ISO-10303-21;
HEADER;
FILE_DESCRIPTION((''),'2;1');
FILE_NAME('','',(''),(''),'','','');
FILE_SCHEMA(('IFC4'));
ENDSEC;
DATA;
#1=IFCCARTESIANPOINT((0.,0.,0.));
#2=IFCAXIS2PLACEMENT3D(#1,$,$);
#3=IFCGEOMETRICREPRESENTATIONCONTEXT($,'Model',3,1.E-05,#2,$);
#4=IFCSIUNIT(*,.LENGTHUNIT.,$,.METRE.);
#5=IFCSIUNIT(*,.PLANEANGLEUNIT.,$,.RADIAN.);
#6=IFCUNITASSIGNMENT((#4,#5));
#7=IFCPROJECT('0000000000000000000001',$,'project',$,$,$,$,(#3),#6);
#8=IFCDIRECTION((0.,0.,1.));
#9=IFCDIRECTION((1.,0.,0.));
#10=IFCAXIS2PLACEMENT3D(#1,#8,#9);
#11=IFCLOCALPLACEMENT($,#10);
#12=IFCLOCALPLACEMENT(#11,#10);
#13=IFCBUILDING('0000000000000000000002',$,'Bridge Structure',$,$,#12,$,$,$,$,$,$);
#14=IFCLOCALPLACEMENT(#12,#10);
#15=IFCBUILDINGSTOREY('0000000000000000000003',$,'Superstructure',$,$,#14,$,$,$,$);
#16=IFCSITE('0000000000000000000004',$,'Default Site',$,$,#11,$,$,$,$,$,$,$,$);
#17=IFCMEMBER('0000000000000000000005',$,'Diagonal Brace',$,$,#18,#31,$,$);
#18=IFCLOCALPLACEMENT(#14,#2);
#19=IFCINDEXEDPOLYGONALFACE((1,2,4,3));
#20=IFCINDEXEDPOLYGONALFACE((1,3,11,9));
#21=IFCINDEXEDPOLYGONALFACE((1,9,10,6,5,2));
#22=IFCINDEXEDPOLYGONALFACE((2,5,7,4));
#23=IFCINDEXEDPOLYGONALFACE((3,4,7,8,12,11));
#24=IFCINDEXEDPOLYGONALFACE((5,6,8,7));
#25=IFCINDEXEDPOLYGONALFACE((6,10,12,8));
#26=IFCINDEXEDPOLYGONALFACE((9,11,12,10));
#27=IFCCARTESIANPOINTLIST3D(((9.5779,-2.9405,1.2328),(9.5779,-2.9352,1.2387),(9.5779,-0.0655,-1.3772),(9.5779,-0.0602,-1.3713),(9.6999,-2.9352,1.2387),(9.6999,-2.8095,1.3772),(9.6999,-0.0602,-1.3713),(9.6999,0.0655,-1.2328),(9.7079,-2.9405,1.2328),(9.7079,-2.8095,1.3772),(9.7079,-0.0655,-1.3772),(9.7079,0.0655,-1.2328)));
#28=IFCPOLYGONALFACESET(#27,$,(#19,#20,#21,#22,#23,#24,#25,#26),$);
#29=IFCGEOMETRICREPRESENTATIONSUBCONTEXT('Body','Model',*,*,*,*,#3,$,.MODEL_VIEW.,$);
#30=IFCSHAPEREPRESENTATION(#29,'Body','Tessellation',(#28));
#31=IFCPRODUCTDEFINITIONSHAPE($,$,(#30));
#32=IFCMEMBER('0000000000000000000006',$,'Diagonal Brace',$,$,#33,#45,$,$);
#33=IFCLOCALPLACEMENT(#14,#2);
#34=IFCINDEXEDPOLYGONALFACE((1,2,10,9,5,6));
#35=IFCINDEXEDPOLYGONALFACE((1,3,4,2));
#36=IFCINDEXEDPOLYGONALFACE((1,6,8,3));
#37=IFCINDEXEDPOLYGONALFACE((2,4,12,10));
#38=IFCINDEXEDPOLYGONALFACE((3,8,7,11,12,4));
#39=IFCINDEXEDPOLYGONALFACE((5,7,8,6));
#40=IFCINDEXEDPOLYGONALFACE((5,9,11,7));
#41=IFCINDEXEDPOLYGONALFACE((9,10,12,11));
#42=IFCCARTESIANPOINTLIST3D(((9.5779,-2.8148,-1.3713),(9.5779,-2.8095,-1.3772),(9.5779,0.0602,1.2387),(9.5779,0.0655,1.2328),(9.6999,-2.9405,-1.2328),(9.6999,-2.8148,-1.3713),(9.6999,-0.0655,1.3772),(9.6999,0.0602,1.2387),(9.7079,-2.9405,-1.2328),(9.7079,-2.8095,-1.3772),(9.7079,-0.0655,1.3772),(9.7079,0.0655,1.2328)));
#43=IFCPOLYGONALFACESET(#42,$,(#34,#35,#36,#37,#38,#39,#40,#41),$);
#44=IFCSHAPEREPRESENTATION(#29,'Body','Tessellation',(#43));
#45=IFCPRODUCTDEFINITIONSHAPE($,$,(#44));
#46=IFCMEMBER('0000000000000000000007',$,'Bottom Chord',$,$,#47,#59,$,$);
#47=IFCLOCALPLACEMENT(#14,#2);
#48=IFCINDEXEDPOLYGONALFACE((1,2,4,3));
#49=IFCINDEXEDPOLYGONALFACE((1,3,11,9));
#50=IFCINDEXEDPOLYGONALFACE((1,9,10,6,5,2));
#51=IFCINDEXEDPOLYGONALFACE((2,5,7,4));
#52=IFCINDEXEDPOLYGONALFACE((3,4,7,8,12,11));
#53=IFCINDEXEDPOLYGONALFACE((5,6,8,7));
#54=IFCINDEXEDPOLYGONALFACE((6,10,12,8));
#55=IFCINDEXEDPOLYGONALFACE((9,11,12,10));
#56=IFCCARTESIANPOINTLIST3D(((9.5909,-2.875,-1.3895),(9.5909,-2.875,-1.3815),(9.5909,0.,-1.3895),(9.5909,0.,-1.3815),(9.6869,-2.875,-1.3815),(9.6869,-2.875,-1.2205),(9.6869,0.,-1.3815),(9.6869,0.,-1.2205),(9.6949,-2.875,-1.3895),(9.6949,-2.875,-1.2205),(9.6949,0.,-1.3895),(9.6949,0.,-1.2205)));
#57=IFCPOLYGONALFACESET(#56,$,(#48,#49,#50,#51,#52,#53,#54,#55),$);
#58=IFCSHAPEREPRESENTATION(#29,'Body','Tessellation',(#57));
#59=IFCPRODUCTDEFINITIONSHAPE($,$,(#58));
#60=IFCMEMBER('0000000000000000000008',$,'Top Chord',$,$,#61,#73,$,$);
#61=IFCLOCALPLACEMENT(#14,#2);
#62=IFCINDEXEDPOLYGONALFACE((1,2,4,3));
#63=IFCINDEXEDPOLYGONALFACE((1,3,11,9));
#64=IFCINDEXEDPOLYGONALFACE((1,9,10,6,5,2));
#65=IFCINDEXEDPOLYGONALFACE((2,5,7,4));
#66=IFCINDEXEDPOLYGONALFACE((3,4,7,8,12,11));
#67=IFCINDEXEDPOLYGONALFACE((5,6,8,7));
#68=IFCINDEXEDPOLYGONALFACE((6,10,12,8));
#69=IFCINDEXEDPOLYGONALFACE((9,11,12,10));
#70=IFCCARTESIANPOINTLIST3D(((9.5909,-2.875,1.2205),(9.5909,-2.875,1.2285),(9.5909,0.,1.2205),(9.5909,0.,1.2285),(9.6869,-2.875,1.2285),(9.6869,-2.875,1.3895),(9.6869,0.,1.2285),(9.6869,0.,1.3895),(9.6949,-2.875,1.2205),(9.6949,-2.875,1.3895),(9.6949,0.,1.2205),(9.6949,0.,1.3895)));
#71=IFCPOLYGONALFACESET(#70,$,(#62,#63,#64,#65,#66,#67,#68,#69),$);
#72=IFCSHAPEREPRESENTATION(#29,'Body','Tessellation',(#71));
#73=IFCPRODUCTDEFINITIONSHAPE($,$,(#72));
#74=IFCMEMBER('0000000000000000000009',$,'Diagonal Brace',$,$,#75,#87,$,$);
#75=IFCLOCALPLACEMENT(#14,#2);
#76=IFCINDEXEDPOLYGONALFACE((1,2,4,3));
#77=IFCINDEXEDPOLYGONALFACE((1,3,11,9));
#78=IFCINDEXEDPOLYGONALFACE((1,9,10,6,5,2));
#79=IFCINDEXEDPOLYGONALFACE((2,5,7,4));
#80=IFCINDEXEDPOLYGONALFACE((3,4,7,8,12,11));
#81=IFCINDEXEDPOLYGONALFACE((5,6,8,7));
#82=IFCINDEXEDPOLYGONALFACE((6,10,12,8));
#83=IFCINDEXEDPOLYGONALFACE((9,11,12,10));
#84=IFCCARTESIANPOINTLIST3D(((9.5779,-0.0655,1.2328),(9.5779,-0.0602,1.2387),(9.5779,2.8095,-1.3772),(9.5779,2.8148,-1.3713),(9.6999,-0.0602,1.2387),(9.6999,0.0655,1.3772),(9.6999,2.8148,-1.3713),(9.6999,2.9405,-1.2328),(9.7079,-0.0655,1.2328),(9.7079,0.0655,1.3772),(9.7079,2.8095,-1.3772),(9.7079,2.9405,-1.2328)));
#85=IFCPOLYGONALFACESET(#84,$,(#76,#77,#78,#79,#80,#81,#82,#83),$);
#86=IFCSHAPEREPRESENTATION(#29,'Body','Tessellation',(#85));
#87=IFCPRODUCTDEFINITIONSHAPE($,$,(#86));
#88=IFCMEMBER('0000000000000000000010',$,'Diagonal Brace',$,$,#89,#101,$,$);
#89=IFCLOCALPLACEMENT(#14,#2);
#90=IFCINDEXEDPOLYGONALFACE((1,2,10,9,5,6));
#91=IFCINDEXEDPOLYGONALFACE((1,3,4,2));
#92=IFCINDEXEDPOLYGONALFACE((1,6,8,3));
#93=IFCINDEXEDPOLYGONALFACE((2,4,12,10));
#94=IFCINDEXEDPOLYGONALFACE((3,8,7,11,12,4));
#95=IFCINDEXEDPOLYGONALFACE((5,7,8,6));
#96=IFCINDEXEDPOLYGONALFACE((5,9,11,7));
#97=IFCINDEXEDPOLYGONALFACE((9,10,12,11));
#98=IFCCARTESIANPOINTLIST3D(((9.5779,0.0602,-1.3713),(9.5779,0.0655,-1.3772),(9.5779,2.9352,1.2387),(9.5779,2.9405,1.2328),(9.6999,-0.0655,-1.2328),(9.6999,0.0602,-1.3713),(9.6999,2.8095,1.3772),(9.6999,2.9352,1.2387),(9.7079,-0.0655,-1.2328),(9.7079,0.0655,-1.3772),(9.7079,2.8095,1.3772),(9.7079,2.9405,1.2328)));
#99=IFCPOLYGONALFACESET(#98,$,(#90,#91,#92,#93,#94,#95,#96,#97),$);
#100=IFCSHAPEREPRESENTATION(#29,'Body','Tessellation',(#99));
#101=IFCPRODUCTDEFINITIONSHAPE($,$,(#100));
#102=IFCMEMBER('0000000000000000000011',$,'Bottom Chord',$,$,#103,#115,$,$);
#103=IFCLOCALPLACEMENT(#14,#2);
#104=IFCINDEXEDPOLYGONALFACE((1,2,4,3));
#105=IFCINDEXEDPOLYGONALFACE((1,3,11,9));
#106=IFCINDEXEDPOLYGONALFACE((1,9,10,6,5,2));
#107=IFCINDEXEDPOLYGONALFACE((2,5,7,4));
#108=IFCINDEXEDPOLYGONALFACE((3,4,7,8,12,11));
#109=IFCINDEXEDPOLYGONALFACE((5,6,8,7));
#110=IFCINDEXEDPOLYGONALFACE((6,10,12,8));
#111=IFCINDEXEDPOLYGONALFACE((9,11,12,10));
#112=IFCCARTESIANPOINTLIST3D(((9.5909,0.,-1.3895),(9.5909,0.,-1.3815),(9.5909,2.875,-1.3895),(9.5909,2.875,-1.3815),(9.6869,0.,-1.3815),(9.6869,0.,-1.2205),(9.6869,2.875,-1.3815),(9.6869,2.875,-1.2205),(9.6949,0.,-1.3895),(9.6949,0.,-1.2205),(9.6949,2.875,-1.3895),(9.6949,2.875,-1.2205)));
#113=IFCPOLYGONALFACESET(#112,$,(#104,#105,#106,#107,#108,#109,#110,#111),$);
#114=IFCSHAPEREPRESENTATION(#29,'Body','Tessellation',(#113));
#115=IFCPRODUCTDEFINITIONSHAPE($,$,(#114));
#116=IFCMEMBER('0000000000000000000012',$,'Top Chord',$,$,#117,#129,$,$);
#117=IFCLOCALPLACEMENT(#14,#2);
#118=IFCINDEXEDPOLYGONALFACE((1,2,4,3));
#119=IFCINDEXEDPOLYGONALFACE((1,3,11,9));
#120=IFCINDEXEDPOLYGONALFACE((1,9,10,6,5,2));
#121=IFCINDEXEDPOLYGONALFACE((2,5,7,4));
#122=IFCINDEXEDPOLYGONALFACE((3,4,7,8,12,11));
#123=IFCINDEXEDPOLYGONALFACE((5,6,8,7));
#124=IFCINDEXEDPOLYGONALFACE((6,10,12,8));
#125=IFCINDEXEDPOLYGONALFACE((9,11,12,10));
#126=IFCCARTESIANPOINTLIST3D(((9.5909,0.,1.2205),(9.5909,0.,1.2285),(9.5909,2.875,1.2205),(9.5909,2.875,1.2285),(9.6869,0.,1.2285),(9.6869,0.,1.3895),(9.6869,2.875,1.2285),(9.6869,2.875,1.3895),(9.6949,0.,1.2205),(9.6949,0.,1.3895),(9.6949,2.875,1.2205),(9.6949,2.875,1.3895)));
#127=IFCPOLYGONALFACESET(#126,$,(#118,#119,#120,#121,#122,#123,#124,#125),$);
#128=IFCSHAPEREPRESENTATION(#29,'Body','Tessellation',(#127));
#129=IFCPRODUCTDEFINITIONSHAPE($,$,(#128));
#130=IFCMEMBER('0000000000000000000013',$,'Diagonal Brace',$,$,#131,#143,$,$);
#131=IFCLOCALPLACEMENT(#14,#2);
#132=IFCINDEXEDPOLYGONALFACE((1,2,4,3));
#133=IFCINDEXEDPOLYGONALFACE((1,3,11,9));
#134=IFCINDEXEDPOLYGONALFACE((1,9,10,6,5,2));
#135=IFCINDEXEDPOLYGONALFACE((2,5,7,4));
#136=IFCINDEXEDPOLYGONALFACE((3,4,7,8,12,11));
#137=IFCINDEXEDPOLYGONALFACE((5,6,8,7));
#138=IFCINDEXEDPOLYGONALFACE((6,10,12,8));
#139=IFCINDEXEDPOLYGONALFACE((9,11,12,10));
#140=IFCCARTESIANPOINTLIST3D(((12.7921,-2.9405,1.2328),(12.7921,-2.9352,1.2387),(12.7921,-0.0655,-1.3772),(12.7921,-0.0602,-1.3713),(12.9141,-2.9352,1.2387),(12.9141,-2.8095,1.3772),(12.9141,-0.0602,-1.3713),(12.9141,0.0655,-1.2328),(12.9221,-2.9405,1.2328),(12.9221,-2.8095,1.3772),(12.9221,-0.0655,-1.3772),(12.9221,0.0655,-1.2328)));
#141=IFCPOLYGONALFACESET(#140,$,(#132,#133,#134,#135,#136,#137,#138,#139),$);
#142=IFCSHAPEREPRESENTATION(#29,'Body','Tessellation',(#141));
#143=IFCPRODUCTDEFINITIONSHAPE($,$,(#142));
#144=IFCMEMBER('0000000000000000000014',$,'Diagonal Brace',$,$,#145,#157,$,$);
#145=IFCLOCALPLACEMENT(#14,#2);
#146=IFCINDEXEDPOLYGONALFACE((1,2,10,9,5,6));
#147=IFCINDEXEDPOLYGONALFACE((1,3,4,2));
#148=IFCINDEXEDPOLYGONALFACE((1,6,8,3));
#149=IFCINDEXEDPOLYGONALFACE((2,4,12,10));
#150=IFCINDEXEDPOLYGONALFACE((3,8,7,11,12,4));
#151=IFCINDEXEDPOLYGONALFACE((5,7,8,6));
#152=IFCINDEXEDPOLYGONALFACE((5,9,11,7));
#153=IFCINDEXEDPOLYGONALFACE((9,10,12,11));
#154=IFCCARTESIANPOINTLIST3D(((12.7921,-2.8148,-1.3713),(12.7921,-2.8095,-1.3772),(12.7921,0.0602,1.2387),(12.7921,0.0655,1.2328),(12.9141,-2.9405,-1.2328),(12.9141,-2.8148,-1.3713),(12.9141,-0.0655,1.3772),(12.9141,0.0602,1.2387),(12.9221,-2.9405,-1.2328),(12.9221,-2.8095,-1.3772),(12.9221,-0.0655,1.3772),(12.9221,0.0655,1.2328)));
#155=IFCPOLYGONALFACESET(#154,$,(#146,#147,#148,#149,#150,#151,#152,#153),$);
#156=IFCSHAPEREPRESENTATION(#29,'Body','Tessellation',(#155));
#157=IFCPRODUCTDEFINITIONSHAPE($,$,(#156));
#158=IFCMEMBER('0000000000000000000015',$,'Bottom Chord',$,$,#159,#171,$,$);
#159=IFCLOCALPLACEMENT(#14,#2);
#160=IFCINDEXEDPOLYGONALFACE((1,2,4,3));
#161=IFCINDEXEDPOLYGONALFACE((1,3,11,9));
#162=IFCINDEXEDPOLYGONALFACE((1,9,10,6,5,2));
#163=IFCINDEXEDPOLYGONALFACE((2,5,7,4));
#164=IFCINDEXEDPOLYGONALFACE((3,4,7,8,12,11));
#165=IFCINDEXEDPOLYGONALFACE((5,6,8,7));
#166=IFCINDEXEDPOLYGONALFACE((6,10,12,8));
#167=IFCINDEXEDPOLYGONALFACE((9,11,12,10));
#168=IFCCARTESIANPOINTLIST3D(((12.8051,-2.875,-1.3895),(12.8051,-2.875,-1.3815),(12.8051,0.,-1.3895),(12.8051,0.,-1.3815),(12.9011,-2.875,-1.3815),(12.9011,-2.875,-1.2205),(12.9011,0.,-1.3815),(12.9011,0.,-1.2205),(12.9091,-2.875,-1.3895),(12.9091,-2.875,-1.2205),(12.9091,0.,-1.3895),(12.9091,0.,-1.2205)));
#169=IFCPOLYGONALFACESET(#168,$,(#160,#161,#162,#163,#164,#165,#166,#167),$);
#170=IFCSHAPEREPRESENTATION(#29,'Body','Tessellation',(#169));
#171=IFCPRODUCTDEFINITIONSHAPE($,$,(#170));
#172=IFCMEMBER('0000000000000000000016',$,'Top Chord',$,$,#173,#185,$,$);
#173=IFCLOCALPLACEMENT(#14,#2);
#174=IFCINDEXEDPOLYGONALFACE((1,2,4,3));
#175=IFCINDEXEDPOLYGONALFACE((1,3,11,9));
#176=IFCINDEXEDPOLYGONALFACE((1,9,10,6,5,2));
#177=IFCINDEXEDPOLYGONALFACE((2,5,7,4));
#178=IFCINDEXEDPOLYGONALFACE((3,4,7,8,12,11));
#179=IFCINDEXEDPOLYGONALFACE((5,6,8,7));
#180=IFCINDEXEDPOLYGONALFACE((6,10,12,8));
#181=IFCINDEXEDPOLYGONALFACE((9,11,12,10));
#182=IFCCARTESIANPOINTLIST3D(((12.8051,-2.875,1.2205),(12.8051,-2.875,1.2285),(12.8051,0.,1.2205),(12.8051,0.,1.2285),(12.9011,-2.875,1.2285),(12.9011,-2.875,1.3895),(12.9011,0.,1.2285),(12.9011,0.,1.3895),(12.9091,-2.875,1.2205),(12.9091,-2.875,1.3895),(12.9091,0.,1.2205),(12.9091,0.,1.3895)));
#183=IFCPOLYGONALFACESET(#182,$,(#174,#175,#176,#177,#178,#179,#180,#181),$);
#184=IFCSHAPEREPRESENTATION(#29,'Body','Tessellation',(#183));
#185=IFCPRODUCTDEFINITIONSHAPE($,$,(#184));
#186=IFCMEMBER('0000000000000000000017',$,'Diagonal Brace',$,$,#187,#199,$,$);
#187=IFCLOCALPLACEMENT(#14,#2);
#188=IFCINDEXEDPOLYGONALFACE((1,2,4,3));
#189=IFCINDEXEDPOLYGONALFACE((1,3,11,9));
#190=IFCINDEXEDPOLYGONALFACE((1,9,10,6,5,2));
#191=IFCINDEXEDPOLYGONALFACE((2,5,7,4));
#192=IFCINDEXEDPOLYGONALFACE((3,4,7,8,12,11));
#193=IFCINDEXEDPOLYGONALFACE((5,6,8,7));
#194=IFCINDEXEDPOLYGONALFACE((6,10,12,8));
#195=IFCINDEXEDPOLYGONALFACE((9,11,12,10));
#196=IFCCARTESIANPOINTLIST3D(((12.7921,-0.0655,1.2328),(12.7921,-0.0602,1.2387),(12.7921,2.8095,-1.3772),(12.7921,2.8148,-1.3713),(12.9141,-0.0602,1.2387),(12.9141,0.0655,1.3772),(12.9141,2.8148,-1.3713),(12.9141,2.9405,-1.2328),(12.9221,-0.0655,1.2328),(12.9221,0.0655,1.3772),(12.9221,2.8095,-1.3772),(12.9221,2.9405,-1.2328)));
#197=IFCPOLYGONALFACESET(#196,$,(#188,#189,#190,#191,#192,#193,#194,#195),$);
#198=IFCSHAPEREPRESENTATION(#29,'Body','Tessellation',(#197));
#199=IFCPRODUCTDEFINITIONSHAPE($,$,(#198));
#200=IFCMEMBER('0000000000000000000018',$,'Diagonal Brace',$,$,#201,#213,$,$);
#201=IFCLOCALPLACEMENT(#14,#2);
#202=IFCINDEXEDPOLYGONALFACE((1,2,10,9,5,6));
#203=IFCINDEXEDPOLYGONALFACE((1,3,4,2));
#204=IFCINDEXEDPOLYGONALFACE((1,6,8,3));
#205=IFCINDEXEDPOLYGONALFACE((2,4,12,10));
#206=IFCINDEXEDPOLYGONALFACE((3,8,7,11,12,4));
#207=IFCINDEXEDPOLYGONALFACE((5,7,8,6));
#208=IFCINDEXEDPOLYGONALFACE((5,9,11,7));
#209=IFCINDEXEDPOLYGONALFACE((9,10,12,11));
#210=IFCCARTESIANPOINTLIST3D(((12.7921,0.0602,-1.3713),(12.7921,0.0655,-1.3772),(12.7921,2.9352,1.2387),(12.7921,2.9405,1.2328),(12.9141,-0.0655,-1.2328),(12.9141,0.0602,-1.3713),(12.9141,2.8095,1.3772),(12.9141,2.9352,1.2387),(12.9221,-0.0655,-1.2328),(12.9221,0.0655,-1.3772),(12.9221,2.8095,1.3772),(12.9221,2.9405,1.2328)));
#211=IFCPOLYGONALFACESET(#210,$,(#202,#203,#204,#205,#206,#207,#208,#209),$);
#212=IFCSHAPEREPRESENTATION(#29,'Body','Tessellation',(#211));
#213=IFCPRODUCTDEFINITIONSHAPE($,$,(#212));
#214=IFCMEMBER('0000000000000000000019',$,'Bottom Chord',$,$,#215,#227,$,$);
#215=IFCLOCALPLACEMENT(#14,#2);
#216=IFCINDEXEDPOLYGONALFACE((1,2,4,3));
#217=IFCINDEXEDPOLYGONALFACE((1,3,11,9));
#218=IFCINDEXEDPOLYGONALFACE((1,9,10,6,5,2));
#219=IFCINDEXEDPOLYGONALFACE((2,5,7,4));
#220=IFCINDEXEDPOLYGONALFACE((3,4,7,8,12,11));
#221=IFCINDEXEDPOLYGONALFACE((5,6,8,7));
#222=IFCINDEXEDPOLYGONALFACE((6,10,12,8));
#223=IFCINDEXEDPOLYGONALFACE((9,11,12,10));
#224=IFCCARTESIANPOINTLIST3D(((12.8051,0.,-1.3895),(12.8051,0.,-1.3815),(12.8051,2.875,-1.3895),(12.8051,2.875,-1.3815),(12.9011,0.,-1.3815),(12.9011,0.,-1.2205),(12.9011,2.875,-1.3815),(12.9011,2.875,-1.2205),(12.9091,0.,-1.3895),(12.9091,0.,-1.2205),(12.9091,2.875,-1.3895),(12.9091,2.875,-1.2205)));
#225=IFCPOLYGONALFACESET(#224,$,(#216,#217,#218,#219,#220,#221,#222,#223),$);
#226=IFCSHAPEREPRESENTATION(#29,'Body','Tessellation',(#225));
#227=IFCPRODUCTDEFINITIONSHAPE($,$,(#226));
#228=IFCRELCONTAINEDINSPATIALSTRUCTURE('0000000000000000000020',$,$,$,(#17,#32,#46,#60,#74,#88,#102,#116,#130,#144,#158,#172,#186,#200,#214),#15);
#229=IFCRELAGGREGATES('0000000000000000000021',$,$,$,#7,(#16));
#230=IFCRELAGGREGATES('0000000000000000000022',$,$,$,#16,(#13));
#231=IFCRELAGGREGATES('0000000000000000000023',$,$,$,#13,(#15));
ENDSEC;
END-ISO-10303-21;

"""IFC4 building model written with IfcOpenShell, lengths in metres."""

from ifc_helpers import new_model, si_unit, frame, origin, origin_with_axes, origin_2d_with_axis, place, context, subcontext, project, spatial, l_section, extrude, element, save


model = new_model("IFC4")

# Units and contexts
model_context = context("Model", 3, precision=1e-05, world=origin())
body_context = subcontext(model_context, "Body", "Model", "MODEL_VIEW")
ifc_project = project(units=[si_unit("LENGTHUNIT", "METRE"), si_unit("PLANEANGLEUNIT", "RADIAN")], contexts=[model_context])

# Site, building, storey
site_placement = place(None, origin_with_axes())
site = spatial("IfcSite", under=ifc_project, at=site_placement, Name="Default Site")
building_placement = place(site_placement, origin_with_axes())
building = spatial("IfcBuilding", under=site, at=building_placement, Name="Bridge Structure")
storey_placement = place(building_placement, origin_with_axes())
storey = spatial("IfcBuildingStorey", under=building, at=storey_placement, Name="Superstructure")

# Members
for number, where, z_axis, x_axis, name in (
    (1, (9.6429, -2.875, 1.305), (0.0, 0.740406, -0.67216), (-1.0, 0.0, 0.0), "Diagonal Brace"),
    (2, (9.6429, -2.875, -1.305), (0.0, 0.740406, 0.67216), (-1.0, 0.0, 0.0), "Diagonal Brace"),
):
    element("IfcMember", number, at=place(storey_placement, frame(where, z_axis=z_axis, x_axis=x_axis)), inside=storey, Name=name, context=body_context, shape_type="SweptSolid", body=[
        extrude(l_section(Depth=0.195, Width=0.13, Thickness=0.008, at=origin_2d_with_axis()), origin_with_axes(), (0.0, 0.0, 1.0), 3.883),
    ])
for number, where, z_axis, x_axis, name in (
    (3, (9.6429, -2.875, -1.305), (0.0, 1.0, 0.0), (-1.0, 0.0, 0.0), "Bottom Chord"),
    (4, (9.6429, -2.875, 1.305), (0.0, 1.0, 0.0), (-1.0, 0.0, 0.0), "Top Chord"),
):
    element("IfcMember", number, at=place(storey_placement, frame(where, z_axis=z_axis, x_axis=x_axis)), inside=storey, Name=name, context=body_context, shape_type="SweptSolid", body=[
        extrude(l_section(Depth=0.169, Width=0.104, Thickness=0.008, at=origin_2d_with_axis()), origin_with_axes(), (0.0, 0.0, 1.0), 2.875),
    ])
for number, where, z_axis, x_axis, name in (
    (5, (9.6429, 0.0, 1.305), (0.0, 0.740406, -0.67216), (-1.0, 0.0, 0.0), "Diagonal Brace"),
    (6, (9.6429, 0.0, -1.305), (0.0, 0.740406, 0.67216), (-1.0, 0.0, 0.0), "Diagonal Brace"),
):
    element("IfcMember", number, at=place(storey_placement, frame(where, z_axis=z_axis, x_axis=x_axis)), inside=storey, Name=name, context=body_context, shape_type="SweptSolid", body=[
        extrude(l_section(Depth=0.195, Width=0.13, Thickness=0.008, at=origin_2d_with_axis()), origin_with_axes(), (0.0, 0.0, 1.0), 3.883),
    ])
for number, where, z_axis, x_axis, name in (
    (7, (9.6429, 0.0, -1.305), (0.0, 1.0, 0.0), (-1.0, 0.0, 0.0), "Bottom Chord"),
    (8, (9.6429, 0.0, 1.305), (0.0, 1.0, 0.0), (-1.0, 0.0, 0.0), "Top Chord"),
):
    element("IfcMember", number, at=place(storey_placement, frame(where, z_axis=z_axis, x_axis=x_axis)), inside=storey, Name=name, context=body_context, shape_type="SweptSolid", body=[
        extrude(l_section(Depth=0.169, Width=0.104, Thickness=0.008, at=origin_2d_with_axis()), origin_with_axes(), (0.0, 0.0, 1.0), 2.875),
    ])
for number, where, z_axis, x_axis, name in (
    (9, (12.8571, -2.875, 1.305), (0.0, 0.740406, -0.67216), (-1.0, 0.0, 0.0), "Diagonal Brace"),
    (10, (12.8571, -2.875, -1.305), (0.0, 0.740406, 0.67216), (-1.0, 0.0, 0.0), "Diagonal Brace"),
):
    element("IfcMember", number, at=place(storey_placement, frame(where, z_axis=z_axis, x_axis=x_axis)), inside=storey, Name=name, context=body_context, shape_type="SweptSolid", body=[
        extrude(l_section(Depth=0.195, Width=0.13, Thickness=0.008, at=origin_2d_with_axis()), origin_with_axes(), (0.0, 0.0, 1.0), 3.883),
    ])
for number, where, z_axis, x_axis, name in (
    (11, (12.8571, -2.875, -1.305), (0.0, 1.0, 0.0), (-1.0, 0.0, 0.0), "Bottom Chord"),
    (12, (12.8571, -2.875, 1.305), (0.0, 1.0, 0.0), (-1.0, 0.0, 0.0), "Top Chord"),
):
    element("IfcMember", number, at=place(storey_placement, frame(where, z_axis=z_axis, x_axis=x_axis)), inside=storey, Name=name, context=body_context, shape_type="SweptSolid", body=[
        extrude(l_section(Depth=0.169, Width=0.104, Thickness=0.008, at=origin_2d_with_axis()), origin_with_axes(), (0.0, 0.0, 1.0), 2.875),
    ])
for number, where, z_axis, x_axis, name in (
    (13, (12.8571, 0.0, 1.305), (0.0, 0.740406, -0.67216), (-1.0, 0.0, 0.0), "Diagonal Brace"),
    (14, (12.8571, 0.0, -1.305), (0.0, 0.740406, 0.67216), (-1.0, 0.0, 0.0), "Diagonal Brace"),
):
    element("IfcMember", number, at=place(storey_placement, frame(where, z_axis=z_axis, x_axis=x_axis)), inside=storey, Name=name, context=body_context, shape_type="SweptSolid", body=[
        extrude(l_section(Depth=0.195, Width=0.13, Thickness=0.008, at=origin_2d_with_axis()), origin_with_axes(), (0.0, 0.0, 1.0), 3.883),
    ])
for number, where, z_axis, x_axis, name in (
    (15, (12.8571, 0.0, -1.305), (0.0, 1.0, 0.0), (-1.0, 0.0, 0.0), "Bottom Chord"),
):
    element("IfcMember", number, at=place(storey_placement, frame(where, z_axis=z_axis, x_axis=x_axis)), inside=storey, Name=name, context=body_context, shape_type="SweptSolid", body=[
        extrude(l_section(Depth=0.169, Width=0.104, Thickness=0.008, at=origin_2d_with_axis()), origin_with_axes(), (0.0, 0.0, 1.0), 2.875),
    ])

save(model, "model.ifc")
